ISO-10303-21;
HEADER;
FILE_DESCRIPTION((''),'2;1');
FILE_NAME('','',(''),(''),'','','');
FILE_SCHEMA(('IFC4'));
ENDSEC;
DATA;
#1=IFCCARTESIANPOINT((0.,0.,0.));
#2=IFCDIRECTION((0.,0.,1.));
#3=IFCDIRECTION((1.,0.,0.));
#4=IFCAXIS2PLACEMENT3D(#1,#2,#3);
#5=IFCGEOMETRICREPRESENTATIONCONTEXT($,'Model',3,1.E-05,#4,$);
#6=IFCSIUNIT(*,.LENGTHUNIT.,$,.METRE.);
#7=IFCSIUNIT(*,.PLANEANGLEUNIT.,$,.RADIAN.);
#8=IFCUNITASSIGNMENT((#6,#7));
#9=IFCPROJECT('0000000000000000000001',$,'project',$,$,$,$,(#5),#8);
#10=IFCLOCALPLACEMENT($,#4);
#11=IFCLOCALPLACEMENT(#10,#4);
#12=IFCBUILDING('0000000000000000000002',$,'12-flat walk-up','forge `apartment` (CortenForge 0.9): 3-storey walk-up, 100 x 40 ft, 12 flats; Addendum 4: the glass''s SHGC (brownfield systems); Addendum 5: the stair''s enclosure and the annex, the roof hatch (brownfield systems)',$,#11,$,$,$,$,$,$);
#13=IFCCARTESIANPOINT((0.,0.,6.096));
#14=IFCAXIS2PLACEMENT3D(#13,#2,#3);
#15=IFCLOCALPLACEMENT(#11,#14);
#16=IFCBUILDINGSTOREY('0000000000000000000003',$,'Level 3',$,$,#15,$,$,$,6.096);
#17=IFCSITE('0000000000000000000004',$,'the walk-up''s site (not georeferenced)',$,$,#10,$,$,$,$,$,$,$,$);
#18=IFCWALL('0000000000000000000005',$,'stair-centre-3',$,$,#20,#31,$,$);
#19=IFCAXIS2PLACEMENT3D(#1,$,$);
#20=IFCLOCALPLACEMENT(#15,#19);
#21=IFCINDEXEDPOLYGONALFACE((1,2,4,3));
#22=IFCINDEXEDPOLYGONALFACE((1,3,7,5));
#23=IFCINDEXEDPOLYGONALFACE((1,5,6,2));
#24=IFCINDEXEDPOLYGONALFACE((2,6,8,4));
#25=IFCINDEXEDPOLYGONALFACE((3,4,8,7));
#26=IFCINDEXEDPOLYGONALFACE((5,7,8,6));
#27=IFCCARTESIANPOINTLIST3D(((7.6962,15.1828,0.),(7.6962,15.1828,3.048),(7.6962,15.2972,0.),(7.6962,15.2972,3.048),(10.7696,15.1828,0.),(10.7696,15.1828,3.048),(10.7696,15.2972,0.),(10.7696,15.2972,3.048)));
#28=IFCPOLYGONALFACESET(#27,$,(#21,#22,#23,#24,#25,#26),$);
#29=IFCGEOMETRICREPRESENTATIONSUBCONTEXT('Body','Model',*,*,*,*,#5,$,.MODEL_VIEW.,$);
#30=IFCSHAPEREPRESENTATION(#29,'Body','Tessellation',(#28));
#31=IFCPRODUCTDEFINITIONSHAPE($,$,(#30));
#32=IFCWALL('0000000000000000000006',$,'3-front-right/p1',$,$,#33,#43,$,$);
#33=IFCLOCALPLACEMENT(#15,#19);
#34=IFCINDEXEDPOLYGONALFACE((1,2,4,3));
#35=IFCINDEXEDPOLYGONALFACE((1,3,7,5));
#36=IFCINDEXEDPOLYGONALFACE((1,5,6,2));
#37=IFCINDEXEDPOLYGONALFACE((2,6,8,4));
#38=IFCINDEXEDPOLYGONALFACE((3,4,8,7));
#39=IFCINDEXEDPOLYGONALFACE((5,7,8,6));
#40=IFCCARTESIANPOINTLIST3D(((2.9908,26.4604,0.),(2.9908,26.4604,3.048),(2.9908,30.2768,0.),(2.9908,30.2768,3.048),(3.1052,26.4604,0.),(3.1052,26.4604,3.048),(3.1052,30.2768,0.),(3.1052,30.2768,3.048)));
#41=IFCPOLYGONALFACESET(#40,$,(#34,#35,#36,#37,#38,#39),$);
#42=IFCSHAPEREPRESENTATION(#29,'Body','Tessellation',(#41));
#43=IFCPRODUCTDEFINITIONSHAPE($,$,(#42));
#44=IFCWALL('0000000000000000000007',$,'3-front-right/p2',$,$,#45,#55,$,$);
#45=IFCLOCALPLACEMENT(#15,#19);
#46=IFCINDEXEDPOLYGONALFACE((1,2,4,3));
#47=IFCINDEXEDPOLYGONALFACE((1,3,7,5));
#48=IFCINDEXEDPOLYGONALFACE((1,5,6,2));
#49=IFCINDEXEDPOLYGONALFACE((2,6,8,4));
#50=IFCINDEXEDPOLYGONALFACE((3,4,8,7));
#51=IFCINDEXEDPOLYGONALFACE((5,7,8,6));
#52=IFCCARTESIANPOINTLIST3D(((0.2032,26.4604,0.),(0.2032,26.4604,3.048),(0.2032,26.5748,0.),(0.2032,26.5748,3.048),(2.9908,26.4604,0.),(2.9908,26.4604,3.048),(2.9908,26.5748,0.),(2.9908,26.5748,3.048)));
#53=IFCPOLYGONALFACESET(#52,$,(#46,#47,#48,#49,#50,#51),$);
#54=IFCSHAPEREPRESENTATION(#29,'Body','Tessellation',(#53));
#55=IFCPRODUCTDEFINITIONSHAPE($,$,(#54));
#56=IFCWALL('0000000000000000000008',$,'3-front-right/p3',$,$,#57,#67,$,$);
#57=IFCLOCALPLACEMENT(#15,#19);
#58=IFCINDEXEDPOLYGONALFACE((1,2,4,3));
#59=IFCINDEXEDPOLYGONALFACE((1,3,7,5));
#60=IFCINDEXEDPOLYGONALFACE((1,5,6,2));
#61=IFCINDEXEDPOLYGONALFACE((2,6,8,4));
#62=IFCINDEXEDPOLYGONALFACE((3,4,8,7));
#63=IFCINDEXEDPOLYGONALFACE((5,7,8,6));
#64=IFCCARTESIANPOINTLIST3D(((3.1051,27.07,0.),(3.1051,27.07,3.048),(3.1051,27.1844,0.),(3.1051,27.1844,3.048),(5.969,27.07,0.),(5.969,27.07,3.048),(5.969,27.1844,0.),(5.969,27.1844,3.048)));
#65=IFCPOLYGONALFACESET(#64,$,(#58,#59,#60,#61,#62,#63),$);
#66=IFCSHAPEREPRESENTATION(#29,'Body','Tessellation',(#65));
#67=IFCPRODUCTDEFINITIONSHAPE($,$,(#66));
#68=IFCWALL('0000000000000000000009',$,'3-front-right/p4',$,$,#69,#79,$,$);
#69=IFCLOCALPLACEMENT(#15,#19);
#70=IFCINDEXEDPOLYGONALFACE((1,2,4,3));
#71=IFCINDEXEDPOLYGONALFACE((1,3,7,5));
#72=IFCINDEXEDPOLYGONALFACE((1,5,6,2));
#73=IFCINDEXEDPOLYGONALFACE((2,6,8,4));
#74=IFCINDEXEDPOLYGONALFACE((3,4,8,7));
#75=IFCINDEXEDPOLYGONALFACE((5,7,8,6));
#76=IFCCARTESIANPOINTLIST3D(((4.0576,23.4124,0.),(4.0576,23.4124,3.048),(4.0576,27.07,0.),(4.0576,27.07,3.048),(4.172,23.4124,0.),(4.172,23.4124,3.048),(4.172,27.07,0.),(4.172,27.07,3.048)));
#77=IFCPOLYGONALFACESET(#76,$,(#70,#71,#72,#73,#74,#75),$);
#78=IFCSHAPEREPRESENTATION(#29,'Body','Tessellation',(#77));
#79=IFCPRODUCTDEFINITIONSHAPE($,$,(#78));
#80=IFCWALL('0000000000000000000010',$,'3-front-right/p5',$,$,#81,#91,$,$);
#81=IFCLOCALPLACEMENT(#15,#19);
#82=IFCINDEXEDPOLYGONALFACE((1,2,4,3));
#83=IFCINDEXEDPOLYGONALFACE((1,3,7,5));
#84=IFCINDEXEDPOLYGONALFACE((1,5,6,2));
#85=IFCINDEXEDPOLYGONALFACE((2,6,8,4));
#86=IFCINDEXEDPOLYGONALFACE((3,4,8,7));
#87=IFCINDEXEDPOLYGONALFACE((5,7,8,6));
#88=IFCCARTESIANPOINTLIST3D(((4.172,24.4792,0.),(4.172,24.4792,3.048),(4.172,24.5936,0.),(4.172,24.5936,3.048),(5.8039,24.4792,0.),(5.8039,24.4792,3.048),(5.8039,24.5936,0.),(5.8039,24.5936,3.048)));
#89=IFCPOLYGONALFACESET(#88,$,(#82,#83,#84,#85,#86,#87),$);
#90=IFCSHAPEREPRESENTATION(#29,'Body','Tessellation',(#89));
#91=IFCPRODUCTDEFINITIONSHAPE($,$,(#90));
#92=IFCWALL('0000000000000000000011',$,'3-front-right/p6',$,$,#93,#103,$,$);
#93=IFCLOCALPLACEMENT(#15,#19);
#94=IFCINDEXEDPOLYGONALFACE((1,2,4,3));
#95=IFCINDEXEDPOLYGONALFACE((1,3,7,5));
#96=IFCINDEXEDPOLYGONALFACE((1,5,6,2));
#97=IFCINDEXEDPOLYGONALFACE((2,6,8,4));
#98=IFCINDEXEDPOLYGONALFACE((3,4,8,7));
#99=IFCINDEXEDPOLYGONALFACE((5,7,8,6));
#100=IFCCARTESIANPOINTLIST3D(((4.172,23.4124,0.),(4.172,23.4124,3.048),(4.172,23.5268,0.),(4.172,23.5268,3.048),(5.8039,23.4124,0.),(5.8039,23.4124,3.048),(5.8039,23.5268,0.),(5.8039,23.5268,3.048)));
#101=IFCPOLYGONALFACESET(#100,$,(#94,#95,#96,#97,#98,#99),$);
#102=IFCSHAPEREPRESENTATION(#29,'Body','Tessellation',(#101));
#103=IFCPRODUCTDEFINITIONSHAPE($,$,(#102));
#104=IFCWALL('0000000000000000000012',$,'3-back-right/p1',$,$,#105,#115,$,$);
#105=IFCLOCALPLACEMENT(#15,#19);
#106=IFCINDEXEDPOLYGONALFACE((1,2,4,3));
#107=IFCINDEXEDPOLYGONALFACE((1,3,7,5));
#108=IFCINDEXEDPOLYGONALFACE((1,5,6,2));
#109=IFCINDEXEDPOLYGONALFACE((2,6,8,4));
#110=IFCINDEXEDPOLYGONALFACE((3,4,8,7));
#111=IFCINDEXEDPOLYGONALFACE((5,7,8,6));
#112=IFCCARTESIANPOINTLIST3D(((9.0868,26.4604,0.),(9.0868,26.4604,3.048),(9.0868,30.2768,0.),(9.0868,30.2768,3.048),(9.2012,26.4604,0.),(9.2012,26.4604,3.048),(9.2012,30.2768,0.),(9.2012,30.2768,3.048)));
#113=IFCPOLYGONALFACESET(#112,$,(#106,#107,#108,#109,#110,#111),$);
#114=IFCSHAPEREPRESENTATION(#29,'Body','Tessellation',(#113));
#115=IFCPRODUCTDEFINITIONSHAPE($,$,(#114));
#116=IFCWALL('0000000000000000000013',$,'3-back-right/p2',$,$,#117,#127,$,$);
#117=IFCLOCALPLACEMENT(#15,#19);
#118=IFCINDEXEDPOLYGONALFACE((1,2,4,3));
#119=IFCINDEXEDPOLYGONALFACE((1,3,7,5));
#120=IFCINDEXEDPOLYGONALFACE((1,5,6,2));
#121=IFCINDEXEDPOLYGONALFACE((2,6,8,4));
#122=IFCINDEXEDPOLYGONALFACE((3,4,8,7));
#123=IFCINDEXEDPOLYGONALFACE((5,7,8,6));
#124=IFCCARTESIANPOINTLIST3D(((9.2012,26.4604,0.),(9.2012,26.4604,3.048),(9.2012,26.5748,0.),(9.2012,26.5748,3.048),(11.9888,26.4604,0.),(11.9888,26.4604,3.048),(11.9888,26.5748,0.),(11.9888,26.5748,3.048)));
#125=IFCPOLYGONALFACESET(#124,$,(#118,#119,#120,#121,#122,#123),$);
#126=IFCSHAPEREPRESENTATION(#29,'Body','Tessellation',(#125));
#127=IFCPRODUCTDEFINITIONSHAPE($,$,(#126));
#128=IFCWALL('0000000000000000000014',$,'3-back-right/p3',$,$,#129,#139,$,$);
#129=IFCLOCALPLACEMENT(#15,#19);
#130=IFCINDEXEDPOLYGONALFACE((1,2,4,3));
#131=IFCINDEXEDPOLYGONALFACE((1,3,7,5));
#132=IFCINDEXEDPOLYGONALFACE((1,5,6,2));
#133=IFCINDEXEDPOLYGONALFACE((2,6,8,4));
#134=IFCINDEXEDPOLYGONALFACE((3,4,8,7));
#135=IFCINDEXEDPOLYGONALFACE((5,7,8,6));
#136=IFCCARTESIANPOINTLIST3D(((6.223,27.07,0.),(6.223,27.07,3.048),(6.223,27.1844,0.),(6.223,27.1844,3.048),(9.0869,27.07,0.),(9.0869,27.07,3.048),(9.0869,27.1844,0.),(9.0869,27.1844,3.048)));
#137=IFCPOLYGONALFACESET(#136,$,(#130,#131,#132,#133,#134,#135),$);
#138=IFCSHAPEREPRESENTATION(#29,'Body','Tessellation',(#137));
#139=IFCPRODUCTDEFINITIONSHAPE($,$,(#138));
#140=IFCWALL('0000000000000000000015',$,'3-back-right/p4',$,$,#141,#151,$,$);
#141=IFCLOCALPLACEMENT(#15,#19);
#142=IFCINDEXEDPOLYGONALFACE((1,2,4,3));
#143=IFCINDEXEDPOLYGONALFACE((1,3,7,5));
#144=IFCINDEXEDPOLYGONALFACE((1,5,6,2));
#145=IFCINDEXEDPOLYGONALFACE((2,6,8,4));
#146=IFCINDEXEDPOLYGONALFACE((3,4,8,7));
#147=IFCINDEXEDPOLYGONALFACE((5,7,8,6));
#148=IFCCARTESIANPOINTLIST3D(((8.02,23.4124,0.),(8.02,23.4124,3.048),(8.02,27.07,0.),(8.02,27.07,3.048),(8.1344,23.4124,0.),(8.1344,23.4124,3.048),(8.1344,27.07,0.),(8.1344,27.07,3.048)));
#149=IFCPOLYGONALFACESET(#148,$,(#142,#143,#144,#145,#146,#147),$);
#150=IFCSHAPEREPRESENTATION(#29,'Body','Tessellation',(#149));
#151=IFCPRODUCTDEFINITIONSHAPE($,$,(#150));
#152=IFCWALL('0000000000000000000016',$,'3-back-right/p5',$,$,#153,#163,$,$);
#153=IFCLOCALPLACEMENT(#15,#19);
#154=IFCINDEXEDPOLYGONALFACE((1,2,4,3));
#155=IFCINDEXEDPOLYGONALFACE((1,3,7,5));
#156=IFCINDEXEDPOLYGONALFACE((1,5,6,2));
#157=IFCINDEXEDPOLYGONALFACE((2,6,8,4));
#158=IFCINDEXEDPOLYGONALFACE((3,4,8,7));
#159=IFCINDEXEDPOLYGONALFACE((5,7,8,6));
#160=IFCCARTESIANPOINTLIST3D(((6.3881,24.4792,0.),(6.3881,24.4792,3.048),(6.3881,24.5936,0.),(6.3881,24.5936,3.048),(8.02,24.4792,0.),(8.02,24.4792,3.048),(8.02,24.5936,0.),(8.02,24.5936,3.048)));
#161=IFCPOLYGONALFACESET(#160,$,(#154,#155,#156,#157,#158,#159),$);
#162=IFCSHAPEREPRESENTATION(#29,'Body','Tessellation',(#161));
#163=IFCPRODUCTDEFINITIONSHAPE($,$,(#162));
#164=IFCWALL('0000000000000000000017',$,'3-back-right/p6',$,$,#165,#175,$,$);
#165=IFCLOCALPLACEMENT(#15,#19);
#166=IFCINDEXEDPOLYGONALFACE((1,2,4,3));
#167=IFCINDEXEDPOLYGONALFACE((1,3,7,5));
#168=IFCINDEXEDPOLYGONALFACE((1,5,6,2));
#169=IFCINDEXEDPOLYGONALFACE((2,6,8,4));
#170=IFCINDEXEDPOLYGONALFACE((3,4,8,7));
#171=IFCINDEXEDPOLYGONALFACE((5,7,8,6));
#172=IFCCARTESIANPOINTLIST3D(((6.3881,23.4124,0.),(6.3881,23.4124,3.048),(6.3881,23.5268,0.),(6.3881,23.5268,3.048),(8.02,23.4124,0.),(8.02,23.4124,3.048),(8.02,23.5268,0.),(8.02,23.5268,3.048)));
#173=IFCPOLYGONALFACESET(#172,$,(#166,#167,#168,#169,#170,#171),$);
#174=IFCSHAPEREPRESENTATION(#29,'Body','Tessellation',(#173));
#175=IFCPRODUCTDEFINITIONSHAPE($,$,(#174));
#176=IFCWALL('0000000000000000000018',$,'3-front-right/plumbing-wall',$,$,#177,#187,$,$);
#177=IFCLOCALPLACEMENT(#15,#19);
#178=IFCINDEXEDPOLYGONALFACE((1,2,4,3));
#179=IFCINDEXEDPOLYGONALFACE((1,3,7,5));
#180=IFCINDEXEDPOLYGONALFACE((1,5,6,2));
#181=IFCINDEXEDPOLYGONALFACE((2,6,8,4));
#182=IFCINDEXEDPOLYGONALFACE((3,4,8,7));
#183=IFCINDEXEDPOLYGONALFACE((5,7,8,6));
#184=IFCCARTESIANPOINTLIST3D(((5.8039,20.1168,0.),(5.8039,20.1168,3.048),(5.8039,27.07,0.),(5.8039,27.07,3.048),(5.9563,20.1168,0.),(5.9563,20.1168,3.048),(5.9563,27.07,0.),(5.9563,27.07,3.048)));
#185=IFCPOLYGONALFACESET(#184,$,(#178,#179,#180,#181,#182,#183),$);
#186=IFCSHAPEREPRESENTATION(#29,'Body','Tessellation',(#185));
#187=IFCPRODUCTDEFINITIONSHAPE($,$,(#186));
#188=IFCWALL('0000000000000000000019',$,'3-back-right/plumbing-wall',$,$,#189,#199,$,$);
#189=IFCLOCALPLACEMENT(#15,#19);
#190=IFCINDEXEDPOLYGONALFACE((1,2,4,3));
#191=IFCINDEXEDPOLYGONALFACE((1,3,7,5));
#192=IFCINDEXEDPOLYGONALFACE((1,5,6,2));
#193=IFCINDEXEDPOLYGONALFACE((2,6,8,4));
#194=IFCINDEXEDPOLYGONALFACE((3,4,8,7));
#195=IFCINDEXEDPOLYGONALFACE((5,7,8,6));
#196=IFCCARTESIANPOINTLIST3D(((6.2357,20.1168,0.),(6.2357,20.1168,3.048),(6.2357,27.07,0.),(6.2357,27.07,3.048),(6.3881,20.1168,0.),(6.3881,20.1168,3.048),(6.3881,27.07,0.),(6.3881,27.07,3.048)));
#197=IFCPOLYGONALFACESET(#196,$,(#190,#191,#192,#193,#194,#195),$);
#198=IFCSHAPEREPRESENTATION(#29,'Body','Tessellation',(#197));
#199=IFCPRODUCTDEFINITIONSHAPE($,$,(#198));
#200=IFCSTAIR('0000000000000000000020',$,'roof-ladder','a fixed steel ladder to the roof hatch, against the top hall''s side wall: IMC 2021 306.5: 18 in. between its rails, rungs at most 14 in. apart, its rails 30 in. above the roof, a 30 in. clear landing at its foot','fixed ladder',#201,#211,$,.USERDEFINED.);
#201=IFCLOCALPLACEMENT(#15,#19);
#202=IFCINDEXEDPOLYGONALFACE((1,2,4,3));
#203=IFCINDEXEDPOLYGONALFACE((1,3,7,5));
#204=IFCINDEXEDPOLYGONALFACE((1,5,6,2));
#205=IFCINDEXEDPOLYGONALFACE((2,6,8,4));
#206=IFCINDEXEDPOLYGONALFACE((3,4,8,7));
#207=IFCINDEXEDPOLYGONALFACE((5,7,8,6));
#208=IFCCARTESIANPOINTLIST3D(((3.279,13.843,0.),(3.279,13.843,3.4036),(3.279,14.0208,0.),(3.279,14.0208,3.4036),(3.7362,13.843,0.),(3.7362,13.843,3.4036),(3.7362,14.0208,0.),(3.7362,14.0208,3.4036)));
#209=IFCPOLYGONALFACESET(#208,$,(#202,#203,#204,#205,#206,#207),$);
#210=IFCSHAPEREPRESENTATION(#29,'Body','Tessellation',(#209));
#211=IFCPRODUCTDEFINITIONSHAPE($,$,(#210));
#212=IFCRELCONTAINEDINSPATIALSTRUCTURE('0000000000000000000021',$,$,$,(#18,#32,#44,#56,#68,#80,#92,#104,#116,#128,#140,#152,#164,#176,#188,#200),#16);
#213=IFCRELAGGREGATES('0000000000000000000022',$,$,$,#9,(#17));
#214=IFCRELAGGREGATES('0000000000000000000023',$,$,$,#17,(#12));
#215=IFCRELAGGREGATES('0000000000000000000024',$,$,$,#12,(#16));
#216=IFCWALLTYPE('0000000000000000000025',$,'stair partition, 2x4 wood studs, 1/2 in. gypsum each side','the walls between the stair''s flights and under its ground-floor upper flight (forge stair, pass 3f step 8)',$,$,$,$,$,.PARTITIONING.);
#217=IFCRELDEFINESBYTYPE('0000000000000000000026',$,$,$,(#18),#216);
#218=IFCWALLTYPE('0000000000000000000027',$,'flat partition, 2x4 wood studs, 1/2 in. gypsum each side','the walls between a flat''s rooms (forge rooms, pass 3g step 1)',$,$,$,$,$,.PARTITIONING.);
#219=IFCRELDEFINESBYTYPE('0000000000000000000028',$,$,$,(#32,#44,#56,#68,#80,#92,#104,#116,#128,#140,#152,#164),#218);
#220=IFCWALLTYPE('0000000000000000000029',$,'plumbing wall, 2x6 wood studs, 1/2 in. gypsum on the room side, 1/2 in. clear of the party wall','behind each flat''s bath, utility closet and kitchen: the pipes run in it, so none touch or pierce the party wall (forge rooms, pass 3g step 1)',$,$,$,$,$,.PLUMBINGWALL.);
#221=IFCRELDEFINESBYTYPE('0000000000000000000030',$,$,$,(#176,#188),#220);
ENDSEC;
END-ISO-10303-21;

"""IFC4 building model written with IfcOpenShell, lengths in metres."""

from ifc_helpers import new_model, si_unit, frame, frame_2d, origin, origin_with_axes, place, context, subcontext, project, spatial, rectangle, extrude, type_object, element, save


model = new_model("IFC4")

# Units and contexts
model_context = context("Model", 3, precision=1e-05, world=origin_with_axes())
body_context = subcontext(model_context, "Body", "Model", "MODEL_VIEW")
ifc_project = project(units=[si_unit("LENGTHUNIT", "METRE"), si_unit("PLANEANGLEUNIT", "RADIAN")], contexts=[model_context])

# Site, building, storey
site_placement = place(None, origin_with_axes())
site = spatial("IfcSite", under=ifc_project, at=site_placement, Name="the walk-up's site (not georeferenced)")
building_placement = place(site_placement, origin_with_axes())
building = spatial("IfcBuilding", under=site, at=building_placement, Name="12-flat walk-up", Description="forge `apartment` (CortenForge 0.9): 3-storey walk-up, 100 x 40 ft, 12 flats; Addendum 4: the glass's SHGC (brownfield systems); Addendum 5: the stair's enclosure and the annex, the roof hatch (brownfield systems)")
storey_placement = place(building_placement, frame((0.0, 0.0, 6.096), z_axis=(0.0, 0.0, 1.0), x_axis=(1.0, 0.0, 0.0)))
storey = spatial("IfcBuildingStorey", under=building, at=storey_placement, Name="Level 3", Elevation=6.096)

# Walls
wall_type_1 = type_object("IfcWallType", Name="stair partition, 2x4 wood studs, 1/2 in. gypsum each side", Description="the walls between the stair's flights and under its ground-floor upper flight (forge stair, pass 3f step 8)", PredefinedType="PARTITIONING")
wall_1_placement = place(storey_placement, frame((7.6962, 15.1829, 0.0), z_axis=(0.0, 0.0, 1.0), x_axis=(1.0, 0.0, 0.0)))
element("IfcWall", 1, at=wall_1_placement, inside=storey, type_object=wall_type_1, Name="stair-centre-3", context=body_context, shape_type="SweptSolid", body=[
    extrude(rectangle(XDim=3.0734, YDim=0.1143, at=frame_2d((1.5367, 0.0572))), origin(), (0.0, 0.0, 1.0), 3.048),
])
wall_type_2 = type_object("IfcWallType", Name="flat partition, 2x4 wood studs, 1/2 in. gypsum each side", Description="the walls between a flat's rooms (forge rooms, pass 3g step 1)", PredefinedType="PARTITIONING")
wall_2_placement = place(storey_placement, frame((2.9909, 26.4605, 0.0), z_axis=(0.0, 0.0, 1.0), x_axis=(1.0, 0.0, 0.0)))
element("IfcWall", 2, at=wall_2_placement, inside=storey, type_object=wall_type_2, Name="3-front-right/p1", context=body_context, shape_type="SweptSolid", body=[
    extrude(rectangle(XDim=0.1143, YDim=3.8163, at=frame_2d((0.0572, 1.9082))), origin(), (0.0, 0.0, 1.0), 3.048),
])
wall_3_placement = place(storey_placement, frame((0.2032, 26.4605, 0.0), z_axis=(0.0, 0.0, 1.0), x_axis=(1.0, 0.0, 0.0)))
element("IfcWall", 3, at=wall_3_placement, inside=storey, type_object=wall_type_2, Name="3-front-right/p2", context=body_context, shape_type="SweptSolid", body=[
    extrude(rectangle(XDim=2.7877, YDim=0.1143, at=frame_2d((1.3938, 0.0572))), origin(), (0.0, 0.0, 1.0), 3.048),
])
wall_4_placement = place(storey_placement, frame((3.1051, 27.07, 0.0), z_axis=(0.0, 0.0, 1.0), x_axis=(1.0, 0.0, 0.0)))
element("IfcWall", 4, at=wall_4_placement, inside=storey, type_object=wall_type_2, Name="3-front-right/p3", context=body_context, shape_type="SweptSolid", body=[
    extrude(rectangle(XDim=2.8639, YDim=0.1143, at=frame_2d((1.4319, 0.0572))), origin(), (0.0, 0.0, 1.0), 3.048),
])
wall_5_placement = place(storey_placement, frame((4.0576, 23.4124, 0.0), z_axis=(0.0, 0.0, 1.0), x_axis=(1.0, 0.0, 0.0)))
element("IfcWall", 5, at=wall_5_placement, inside=storey, type_object=wall_type_2, Name="3-front-right/p4", context=body_context, shape_type="SweptSolid", body=[
    extrude(rectangle(XDim=0.1143, YDim=3.6576, at=frame_2d((0.0572, 1.8288))), origin(), (0.0, 0.0, 1.0), 3.048),
])
for number, where, z_axis, x_axis, name in (
    (6, (4.1719, 24.4793, 0.0), (0.0, 0.0, 1.0), (1.0, 0.0, 0.0), "3-front-right/p5"),
    (7, (4.1719, 23.4124, 0.0), (0.0, 0.0, 1.0), (1.0, 0.0, 0.0), "3-front-right/p6"),
):
    element("IfcWall", number, at=place(storey_placement, frame(where, z_axis=z_axis, x_axis=x_axis)), inside=storey, type_object=wall_type_2, Name=name, context=body_context, shape_type="SweptSolid", body=[
        extrude(rectangle(XDim=1.6319, YDim=0.1143, at=frame_2d((0.816, 0.0572))), origin(), (0.0, 0.0, 1.0), 3.048),
    ])
wall_6_placement = place(storey_placement, frame((9.0869, 26.4605, 0.0), z_axis=(0.0, 0.0, 1.0), x_axis=(1.0, 0.0, 0.0)))
element("IfcWall", 8, at=wall_6_placement, inside=storey, type_object=wall_type_2, Name="3-back-right/p1", context=body_context, shape_type="SweptSolid", body=[
    extrude(rectangle(XDim=0.1143, YDim=3.8163, at=frame_2d((0.0572, 1.9082))), origin(), (0.0, 0.0, 1.0), 3.048),
])
wall_7_placement = place(storey_placement, frame((9.2012, 26.4605, 0.0), z_axis=(0.0, 0.0, 1.0), x_axis=(1.0, 0.0, 0.0)))
element("IfcWall", 9, at=wall_7_placement, inside=storey, type_object=wall_type_2, Name="3-back-right/p2", context=body_context, shape_type="SweptSolid", body=[
    extrude(rectangle(XDim=2.7876, YDim=0.1143, at=frame_2d((1.3938, 0.0572))), origin(), (0.0, 0.0, 1.0), 3.048),
])
wall_8_placement = place(storey_placement, frame((6.223, 27.07, 0.0), z_axis=(0.0, 0.0, 1.0), x_axis=(1.0, 0.0, 0.0)))
element("IfcWall", 10, at=wall_8_placement, inside=storey, type_object=wall_type_2, Name="3-back-right/p3", context=body_context, shape_type="SweptSolid", body=[
    extrude(rectangle(XDim=2.8639, YDim=0.1143, at=frame_2d((1.4319, 0.0572))), origin(), (0.0, 0.0, 1.0), 3.048),
])
wall_9_placement = place(storey_placement, frame((8.02, 23.4124, 0.0), z_axis=(0.0, 0.0, 1.0), x_axis=(1.0, 0.0, 0.0)))
element("IfcWall", 11, at=wall_9_placement, inside=storey, type_object=wall_type_2, Name="3-back-right/p4", context=body_context, shape_type="SweptSolid", body=[
    extrude(rectangle(XDim=0.1143, YDim=3.6576, at=frame_2d((0.0572, 1.8288))), origin(), (0.0, 0.0, 1.0), 3.048),
])
for number, where, z_axis, x_axis, name in (
    (12, (6.3881, 24.4793, 0.0), (0.0, 0.0, 1.0), (1.0, 0.0, 0.0), "3-back-right/p5"),
    (13, (6.3881, 23.4124, 0.0), (0.0, 0.0, 1.0), (1.0, 0.0, 0.0), "3-back-right/p6"),
):
    element("IfcWall", number, at=place(storey_placement, frame(where, z_axis=z_axis, x_axis=x_axis)), inside=storey, type_object=wall_type_2, Name=name, context=body_context, shape_type="SweptSolid", body=[
        extrude(rectangle(XDim=1.6319, YDim=0.1143, at=frame_2d((0.816, 0.0572))), origin(), (0.0, 0.0, 1.0), 3.048),
    ])
wall_type_3 = type_object("IfcWallType", Name="plumbing wall, 2x6 wood studs, 1/2 in. gypsum on the room side, 1/2 in. clear of the party wall", Description="behind each flat's bath, utility closet and kitchen: the pipes run in it, so none touch or pierce the party wall (forge rooms, pass 3g step 1)", PredefinedType="PLUMBINGWALL")
for number, where, z_axis, x_axis, name in (
    (14, (5.8039, 20.1168, 0.0), (0.0, 0.0, 1.0), (1.0, 0.0, 0.0), "3-front-right/plumbing-wall"),
    (15, (6.2357, 20.1168, 0.0), (0.0, 0.0, 1.0), (1.0, 0.0, 0.0), "3-back-right/plumbing-wall"),
):
    element("IfcWall", number, at=place(storey_placement, frame(where, z_axis=z_axis, x_axis=x_axis)), inside=storey, type_object=wall_type_3, Name=name, context=body_context, shape_type="SweptSolid", body=[
        extrude(rectangle(XDim=0.1524, YDim=6.9532, at=frame_2d((0.0762, 3.4766))), origin(), (0.0, 0.0, 1.0), 3.048),
    ])

# Stair
stair_placement = place(storey_placement, frame((3.279, 13.843, 0.0), z_axis=(0.0, 0.0, 1.0), x_axis=(1.0, 0.0, 0.0)))
element("IfcStair", 16, at=stair_placement, inside=storey, Name="roof-ladder", Description="a fixed steel ladder to the roof hatch, against the top hall's side wall: IMC 2021 306.5: 18 in. between its rails, rungs at most 14 in. apart, its rails 30 in. above the roof, a 30 in. clear landing at its foot", ObjectType="fixed ladder", PredefinedType="USERDEFINED", context=body_context, shape_type="SweptSolid", body=[
    extrude(rectangle(XDim=0.4572, YDim=0.1778, at=frame_2d((0.2286, 0.0889))), origin(), (0.0, 0.0, 1.0), 3.4036),
])

save(model, "model.ifc")
